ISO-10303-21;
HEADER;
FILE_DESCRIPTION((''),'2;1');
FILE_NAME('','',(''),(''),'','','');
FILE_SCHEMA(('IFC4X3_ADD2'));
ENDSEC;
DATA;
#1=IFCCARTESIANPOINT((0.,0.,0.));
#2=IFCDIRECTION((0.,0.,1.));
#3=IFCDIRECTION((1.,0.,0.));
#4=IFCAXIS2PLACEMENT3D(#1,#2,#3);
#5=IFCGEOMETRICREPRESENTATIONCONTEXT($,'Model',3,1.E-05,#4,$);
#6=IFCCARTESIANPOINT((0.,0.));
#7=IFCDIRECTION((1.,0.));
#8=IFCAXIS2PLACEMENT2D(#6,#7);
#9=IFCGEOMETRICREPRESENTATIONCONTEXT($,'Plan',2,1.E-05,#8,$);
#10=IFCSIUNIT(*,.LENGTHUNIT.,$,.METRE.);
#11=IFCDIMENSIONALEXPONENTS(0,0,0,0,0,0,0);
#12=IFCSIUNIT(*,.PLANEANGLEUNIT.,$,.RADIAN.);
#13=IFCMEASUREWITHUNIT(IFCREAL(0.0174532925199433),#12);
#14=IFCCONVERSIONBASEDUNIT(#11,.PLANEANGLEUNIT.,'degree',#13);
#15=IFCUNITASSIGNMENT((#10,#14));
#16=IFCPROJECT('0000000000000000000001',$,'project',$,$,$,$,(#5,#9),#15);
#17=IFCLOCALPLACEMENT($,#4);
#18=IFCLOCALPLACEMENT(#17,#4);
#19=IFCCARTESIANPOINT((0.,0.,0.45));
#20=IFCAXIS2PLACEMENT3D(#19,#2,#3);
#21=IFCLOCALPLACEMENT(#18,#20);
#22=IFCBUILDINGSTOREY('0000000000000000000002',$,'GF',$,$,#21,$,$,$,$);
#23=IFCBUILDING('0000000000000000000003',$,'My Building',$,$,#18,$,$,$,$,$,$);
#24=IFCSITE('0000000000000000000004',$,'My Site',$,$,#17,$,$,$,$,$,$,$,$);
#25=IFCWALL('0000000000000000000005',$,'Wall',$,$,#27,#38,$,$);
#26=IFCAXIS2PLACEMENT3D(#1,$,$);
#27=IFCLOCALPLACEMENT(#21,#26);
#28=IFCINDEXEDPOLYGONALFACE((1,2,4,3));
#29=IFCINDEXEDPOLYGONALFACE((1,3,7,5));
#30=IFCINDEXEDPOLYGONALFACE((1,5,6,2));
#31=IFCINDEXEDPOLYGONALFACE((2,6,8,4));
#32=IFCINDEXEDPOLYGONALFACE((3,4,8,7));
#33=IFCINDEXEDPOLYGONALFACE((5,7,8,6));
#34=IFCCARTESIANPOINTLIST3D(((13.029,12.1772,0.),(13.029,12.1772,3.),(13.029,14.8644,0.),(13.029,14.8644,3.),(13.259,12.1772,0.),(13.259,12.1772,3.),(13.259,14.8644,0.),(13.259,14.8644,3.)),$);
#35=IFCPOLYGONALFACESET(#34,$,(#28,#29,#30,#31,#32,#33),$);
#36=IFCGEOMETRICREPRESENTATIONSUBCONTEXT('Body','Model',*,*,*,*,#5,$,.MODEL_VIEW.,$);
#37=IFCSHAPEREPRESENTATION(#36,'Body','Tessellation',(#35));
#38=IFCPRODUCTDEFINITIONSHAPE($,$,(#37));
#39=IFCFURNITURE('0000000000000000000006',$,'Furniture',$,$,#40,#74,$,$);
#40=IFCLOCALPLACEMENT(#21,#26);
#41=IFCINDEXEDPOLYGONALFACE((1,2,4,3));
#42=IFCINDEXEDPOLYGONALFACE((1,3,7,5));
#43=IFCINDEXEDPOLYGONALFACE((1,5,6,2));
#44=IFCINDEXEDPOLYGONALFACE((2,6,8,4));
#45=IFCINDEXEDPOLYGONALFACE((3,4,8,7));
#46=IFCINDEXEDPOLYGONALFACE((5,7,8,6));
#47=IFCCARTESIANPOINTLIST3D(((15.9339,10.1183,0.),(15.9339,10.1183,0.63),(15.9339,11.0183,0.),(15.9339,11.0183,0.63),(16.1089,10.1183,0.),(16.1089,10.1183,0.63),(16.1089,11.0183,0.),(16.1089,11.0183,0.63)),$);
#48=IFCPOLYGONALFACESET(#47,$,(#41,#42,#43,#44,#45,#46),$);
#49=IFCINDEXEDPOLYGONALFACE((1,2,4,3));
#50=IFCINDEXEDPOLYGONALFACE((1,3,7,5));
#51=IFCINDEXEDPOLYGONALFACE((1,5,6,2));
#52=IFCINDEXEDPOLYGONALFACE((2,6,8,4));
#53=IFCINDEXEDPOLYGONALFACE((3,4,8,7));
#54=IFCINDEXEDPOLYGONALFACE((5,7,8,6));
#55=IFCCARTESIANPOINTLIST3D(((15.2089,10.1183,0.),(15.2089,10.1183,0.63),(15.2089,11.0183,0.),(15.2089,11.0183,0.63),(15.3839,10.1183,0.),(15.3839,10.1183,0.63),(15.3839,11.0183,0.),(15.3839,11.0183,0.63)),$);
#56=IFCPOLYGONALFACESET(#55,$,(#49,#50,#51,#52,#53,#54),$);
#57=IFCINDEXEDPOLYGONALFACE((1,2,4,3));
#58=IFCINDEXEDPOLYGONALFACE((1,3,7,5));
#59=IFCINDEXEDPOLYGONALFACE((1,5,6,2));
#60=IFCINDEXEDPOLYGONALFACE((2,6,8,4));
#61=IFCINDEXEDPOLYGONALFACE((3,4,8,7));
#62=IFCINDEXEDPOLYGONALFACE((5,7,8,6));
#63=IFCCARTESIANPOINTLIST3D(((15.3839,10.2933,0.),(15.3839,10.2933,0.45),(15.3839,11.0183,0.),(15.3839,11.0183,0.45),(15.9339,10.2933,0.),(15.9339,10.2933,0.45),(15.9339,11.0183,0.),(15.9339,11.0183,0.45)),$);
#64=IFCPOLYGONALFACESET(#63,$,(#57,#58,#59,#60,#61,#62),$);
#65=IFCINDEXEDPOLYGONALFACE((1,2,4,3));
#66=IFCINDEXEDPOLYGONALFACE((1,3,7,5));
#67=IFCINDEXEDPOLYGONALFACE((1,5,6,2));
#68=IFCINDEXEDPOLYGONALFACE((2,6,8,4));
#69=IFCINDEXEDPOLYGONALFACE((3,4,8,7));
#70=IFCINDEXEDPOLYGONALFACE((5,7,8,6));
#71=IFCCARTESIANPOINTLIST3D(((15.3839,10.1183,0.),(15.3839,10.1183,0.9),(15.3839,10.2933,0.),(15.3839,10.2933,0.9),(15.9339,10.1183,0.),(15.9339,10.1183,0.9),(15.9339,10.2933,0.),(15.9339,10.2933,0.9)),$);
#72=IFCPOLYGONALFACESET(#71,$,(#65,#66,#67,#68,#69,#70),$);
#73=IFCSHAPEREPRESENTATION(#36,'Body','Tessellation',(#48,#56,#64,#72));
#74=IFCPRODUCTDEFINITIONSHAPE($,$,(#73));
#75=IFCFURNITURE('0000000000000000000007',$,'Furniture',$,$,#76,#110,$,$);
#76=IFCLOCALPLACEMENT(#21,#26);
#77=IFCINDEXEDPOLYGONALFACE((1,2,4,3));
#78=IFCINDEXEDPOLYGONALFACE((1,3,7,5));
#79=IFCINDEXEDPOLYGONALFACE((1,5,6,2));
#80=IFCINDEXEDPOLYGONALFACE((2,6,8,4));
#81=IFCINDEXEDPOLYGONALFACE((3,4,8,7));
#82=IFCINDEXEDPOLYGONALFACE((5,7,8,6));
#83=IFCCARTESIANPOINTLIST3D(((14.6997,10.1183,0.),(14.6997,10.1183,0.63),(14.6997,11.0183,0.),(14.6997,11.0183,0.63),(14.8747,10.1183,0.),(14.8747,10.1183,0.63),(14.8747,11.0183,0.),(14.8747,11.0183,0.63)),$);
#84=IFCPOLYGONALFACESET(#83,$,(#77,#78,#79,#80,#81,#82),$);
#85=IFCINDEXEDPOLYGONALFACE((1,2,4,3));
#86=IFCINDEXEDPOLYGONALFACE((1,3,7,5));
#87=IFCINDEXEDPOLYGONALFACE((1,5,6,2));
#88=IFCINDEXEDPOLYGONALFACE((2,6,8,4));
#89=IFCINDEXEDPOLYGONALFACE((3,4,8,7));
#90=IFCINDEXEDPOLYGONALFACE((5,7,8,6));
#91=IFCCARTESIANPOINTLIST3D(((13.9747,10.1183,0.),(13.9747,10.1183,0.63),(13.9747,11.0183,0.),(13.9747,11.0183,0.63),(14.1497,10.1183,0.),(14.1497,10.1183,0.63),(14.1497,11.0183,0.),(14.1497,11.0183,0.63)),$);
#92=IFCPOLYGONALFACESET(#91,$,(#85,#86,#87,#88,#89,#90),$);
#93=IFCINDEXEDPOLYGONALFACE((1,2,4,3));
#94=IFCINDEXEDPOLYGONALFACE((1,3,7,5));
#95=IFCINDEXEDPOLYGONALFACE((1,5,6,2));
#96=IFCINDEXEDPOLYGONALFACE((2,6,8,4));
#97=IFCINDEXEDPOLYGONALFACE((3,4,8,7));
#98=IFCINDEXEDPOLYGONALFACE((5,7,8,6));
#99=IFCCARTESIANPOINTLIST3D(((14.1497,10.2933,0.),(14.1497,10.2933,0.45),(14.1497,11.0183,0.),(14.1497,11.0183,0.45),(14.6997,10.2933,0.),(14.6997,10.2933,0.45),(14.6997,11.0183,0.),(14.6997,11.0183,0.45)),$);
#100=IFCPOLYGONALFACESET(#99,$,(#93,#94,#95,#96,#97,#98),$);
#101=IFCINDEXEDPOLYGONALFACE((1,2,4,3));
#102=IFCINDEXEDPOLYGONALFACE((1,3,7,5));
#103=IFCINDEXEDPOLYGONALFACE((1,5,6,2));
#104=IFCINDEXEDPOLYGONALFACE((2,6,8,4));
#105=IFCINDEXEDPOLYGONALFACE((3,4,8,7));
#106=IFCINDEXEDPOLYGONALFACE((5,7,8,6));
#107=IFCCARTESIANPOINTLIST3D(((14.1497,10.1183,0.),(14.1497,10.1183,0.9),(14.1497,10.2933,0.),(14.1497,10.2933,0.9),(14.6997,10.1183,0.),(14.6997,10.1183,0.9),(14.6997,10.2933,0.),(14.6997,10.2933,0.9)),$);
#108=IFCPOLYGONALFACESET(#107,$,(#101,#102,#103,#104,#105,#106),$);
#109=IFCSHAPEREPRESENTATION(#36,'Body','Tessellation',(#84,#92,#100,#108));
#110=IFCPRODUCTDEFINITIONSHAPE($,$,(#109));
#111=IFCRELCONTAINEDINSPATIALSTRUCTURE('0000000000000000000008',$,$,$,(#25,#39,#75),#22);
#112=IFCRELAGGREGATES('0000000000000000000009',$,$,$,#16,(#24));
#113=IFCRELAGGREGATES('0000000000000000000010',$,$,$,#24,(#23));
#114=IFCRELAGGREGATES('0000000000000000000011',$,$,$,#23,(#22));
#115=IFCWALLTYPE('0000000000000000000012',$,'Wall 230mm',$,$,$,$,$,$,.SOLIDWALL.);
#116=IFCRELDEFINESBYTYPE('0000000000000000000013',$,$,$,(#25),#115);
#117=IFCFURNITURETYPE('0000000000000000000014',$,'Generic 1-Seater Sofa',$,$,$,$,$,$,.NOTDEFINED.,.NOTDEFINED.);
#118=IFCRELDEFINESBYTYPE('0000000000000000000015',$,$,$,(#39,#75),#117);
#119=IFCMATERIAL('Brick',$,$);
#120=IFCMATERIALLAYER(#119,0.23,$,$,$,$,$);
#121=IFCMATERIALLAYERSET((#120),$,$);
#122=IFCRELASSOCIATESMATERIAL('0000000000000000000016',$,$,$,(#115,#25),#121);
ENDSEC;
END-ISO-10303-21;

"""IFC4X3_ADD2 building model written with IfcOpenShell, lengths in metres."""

from ifc_helpers import new_model, entity, si_unit, converted_unit, frame, origin_with_axes, origin_2d_with_axis, place, context, subcontext, project, spatial, line, indexed_curve, outline, extrude, shape, source, transform, mapped, material, layer, layer_set, layer_usage, type_object, type_shapes, element, save


model = new_model("IFC4X3_ADD2")

# Units and contexts
model_context = context("Model", 3, precision=1e-05, world=origin_with_axes())
plan_context = context("Plan", 2, precision=1e-05, world=origin_2d_with_axis())
body_context_1 = subcontext(model_context, "Body", "Model", "MODEL_VIEW")
body_context_2 = subcontext(plan_context, "Body", "Plan", "PLAN_VIEW")
ifc_project = project(units=[si_unit("LENGTHUNIT", "METRE"), converted_unit("PLANEANGLEUNIT", "degree", entity("IfcReal", 0.0174532925199433), si_unit("PLANEANGLEUNIT", "RADIAN"), dimensions=[0, 0, 0, 0, 0, 0, 0])], contexts=[model_context, plan_context])

# Site, building, storey
site_placement = place(None, origin_with_axes())
site = spatial("IfcSite", under=ifc_project, at=site_placement, Name="My Site")
building_placement = place(site_placement, origin_with_axes())
building = spatial("IfcBuilding", under=site, at=building_placement, Name="My Building")
storey_placement = place(building_placement, frame((0.0, 0.0, 0.45), z_axis=(0.0, 0.0, 1.0), x_axis=(1.0, 0.0, 0.0)))
storey = spatial("IfcBuildingStorey", under=building, at=storey_placement, Name="GF")

# Shared definitions
ifc_material_1 = material(Name="Brick")
ifc_layer_1 = layer(ifc_material_1, 0.23)
ifc_layer_set_1 = layer_set([ifc_layer_1])
wall_type = type_object("IfcWallType", Name="Wall 230mm", PredefinedType="SOLIDWALL", material=ifc_layer_set_1)

# Wall
ifc_layer_usage_1 = layer_usage(ifc_layer_set_1, "AXIS2", "POSITIVE", 0.0)
wall_1_placement = place(storey_placement, frame((13.259, 12.1772, 0.0), z_axis=(0.0, 0.0, 1.0), x_axis=(0.0, 1.0, 0.0)))
element("IfcWall", 1, at=wall_1_placement, inside=storey, type_object=wall_type, material=ifc_layer_usage_1, Name="Wall", context=body_context_1, shape_type="SweptSolid", body=[
    extrude(outline(indexed_curve([(0.0, 0.0), (0.0, 0.23), (2.6872, 0.23), (2.6872, 0.0), (0.0, 0.0)], self_intersect=False)), origin_with_axes(), (0.0, 0.0, 1.0), 3.0),
])

# Furniture
furniture_type = type_object("IfcFurnitureType", Name="Generic 1-Seater Sofa", AssemblyPlace="NOTDEFINED", PredefinedType="NOTDEFINED")
shared_shape_1 = source(origin_with_axes(), body_context_1, "Body", "SweptSolid", [
    extrude(outline(indexed_curve([(0.0, 0.0), (0.175, 0.0), (0.175, 0.9), (0.0, 0.9)], segments=[line(1, 2, 3, 4, 1)])), frame((-0.45, -0.9, 0.0), z_axis=(0.0, 0.0, 1.0), x_axis=(1.0, 0.0, 0.0)), (0.0, 0.0, 1.0), 0.63),
    extrude(outline(indexed_curve([(0.0, 0.0), (0.175, 0.0), (0.175, 0.9), (0.0, 0.9)], segments=[line(1, 2, 3, 4, 1)])), frame((0.275, -0.9, 0.0), z_axis=(0.0, 0.0, 1.0), x_axis=(1.0, 0.0, 0.0)), (0.0, 0.0, 1.0), 0.63),
    extrude(outline(indexed_curve([(0.175, 0.0), (0.725, 0.0), (0.725, 0.725), (0.175, 0.725)], segments=[line(1, 2, 3, 4, 1)])), frame((-0.45, -0.9, 0.0), z_axis=(0.0, 0.0, 1.0), x_axis=(1.0, 0.0, 0.0)), (0.0, 0.0, 1.0), 0.45),
    extrude(outline(indexed_curve([(0.175, 0.725), (0.725, 0.725), (0.725, 0.9), (0.175, 0.9)], segments=[line(1, 2, 3, 4, 1)])), frame((-0.45, -0.9, 0.0), z_axis=(0.0, 0.0, 1.0), x_axis=(1.0, 0.0, 0.0)), (0.0, 0.0, 1.0), 0.9),
])
shared_shape_2 = source(origin_with_axes(), body_context_2, "Body", "Annotation2D", [
    entity("IfcGeometricCurveSet", [entity("IfcIndexedPolyCurve", entity("IfcCartesianPointList2D", [[0.275, -0.175], [0.275, -0.9], [0.45, -0.9], [0.45, 0.0], [0.275, 0.0], [0.275, -0.9], [-0.275, -0.9], [-0.275, 0.0], [-0.275, -0.175], [0.275, -0.175], [0.275, 0.0], [-0.275, 0.0], [-0.45, 0.0], [-0.45, -0.9], [-0.275, -0.9], [-0.275, -0.175]]))]),
])
type_shapes(furniture_type, [shared_shape_1, shared_shape_2])
for number, where, z_axis, x_axis, name in (
    (2, (15.6589, 10.1183, 0.0), (0.0, 0.0, 1.0), (-1.0, 0.0, 0.0), "Furniture"),
    (3, (14.4247, 10.1183, 0.0), (0.0, 0.0, 1.0), (-1.0, 0.0, 0.0), "Furniture"),
):
    element("IfcFurniture", number, at=place(storey_placement, frame(where, z_axis=z_axis, x_axis=x_axis)), inside=storey, type_object=furniture_type, Name=name, shapes=[
        shape(body_context_1, "Body", "MappedRepresentation", [mapped(shared_shape_1, transform((0.0, 0.0, 0.0), x_axis=(1.0, 0.0, 0.0), y_axis=(0.0, 1.0, 0.0), z_axis=(0.0, 0.0, 1.0), scale=1.0))]),
        shape(body_context_2, "Body", "MappedRepresentation", [mapped(shared_shape_2, transform((0.0, 0.0, 0.0), x_axis=(1.0, 0.0, 0.0), y_axis=(0.0, 1.0, 0.0), z_axis=(0.0, 0.0, 1.0), scale=1.0))]),
    ])

save(model, "model.ifc")
